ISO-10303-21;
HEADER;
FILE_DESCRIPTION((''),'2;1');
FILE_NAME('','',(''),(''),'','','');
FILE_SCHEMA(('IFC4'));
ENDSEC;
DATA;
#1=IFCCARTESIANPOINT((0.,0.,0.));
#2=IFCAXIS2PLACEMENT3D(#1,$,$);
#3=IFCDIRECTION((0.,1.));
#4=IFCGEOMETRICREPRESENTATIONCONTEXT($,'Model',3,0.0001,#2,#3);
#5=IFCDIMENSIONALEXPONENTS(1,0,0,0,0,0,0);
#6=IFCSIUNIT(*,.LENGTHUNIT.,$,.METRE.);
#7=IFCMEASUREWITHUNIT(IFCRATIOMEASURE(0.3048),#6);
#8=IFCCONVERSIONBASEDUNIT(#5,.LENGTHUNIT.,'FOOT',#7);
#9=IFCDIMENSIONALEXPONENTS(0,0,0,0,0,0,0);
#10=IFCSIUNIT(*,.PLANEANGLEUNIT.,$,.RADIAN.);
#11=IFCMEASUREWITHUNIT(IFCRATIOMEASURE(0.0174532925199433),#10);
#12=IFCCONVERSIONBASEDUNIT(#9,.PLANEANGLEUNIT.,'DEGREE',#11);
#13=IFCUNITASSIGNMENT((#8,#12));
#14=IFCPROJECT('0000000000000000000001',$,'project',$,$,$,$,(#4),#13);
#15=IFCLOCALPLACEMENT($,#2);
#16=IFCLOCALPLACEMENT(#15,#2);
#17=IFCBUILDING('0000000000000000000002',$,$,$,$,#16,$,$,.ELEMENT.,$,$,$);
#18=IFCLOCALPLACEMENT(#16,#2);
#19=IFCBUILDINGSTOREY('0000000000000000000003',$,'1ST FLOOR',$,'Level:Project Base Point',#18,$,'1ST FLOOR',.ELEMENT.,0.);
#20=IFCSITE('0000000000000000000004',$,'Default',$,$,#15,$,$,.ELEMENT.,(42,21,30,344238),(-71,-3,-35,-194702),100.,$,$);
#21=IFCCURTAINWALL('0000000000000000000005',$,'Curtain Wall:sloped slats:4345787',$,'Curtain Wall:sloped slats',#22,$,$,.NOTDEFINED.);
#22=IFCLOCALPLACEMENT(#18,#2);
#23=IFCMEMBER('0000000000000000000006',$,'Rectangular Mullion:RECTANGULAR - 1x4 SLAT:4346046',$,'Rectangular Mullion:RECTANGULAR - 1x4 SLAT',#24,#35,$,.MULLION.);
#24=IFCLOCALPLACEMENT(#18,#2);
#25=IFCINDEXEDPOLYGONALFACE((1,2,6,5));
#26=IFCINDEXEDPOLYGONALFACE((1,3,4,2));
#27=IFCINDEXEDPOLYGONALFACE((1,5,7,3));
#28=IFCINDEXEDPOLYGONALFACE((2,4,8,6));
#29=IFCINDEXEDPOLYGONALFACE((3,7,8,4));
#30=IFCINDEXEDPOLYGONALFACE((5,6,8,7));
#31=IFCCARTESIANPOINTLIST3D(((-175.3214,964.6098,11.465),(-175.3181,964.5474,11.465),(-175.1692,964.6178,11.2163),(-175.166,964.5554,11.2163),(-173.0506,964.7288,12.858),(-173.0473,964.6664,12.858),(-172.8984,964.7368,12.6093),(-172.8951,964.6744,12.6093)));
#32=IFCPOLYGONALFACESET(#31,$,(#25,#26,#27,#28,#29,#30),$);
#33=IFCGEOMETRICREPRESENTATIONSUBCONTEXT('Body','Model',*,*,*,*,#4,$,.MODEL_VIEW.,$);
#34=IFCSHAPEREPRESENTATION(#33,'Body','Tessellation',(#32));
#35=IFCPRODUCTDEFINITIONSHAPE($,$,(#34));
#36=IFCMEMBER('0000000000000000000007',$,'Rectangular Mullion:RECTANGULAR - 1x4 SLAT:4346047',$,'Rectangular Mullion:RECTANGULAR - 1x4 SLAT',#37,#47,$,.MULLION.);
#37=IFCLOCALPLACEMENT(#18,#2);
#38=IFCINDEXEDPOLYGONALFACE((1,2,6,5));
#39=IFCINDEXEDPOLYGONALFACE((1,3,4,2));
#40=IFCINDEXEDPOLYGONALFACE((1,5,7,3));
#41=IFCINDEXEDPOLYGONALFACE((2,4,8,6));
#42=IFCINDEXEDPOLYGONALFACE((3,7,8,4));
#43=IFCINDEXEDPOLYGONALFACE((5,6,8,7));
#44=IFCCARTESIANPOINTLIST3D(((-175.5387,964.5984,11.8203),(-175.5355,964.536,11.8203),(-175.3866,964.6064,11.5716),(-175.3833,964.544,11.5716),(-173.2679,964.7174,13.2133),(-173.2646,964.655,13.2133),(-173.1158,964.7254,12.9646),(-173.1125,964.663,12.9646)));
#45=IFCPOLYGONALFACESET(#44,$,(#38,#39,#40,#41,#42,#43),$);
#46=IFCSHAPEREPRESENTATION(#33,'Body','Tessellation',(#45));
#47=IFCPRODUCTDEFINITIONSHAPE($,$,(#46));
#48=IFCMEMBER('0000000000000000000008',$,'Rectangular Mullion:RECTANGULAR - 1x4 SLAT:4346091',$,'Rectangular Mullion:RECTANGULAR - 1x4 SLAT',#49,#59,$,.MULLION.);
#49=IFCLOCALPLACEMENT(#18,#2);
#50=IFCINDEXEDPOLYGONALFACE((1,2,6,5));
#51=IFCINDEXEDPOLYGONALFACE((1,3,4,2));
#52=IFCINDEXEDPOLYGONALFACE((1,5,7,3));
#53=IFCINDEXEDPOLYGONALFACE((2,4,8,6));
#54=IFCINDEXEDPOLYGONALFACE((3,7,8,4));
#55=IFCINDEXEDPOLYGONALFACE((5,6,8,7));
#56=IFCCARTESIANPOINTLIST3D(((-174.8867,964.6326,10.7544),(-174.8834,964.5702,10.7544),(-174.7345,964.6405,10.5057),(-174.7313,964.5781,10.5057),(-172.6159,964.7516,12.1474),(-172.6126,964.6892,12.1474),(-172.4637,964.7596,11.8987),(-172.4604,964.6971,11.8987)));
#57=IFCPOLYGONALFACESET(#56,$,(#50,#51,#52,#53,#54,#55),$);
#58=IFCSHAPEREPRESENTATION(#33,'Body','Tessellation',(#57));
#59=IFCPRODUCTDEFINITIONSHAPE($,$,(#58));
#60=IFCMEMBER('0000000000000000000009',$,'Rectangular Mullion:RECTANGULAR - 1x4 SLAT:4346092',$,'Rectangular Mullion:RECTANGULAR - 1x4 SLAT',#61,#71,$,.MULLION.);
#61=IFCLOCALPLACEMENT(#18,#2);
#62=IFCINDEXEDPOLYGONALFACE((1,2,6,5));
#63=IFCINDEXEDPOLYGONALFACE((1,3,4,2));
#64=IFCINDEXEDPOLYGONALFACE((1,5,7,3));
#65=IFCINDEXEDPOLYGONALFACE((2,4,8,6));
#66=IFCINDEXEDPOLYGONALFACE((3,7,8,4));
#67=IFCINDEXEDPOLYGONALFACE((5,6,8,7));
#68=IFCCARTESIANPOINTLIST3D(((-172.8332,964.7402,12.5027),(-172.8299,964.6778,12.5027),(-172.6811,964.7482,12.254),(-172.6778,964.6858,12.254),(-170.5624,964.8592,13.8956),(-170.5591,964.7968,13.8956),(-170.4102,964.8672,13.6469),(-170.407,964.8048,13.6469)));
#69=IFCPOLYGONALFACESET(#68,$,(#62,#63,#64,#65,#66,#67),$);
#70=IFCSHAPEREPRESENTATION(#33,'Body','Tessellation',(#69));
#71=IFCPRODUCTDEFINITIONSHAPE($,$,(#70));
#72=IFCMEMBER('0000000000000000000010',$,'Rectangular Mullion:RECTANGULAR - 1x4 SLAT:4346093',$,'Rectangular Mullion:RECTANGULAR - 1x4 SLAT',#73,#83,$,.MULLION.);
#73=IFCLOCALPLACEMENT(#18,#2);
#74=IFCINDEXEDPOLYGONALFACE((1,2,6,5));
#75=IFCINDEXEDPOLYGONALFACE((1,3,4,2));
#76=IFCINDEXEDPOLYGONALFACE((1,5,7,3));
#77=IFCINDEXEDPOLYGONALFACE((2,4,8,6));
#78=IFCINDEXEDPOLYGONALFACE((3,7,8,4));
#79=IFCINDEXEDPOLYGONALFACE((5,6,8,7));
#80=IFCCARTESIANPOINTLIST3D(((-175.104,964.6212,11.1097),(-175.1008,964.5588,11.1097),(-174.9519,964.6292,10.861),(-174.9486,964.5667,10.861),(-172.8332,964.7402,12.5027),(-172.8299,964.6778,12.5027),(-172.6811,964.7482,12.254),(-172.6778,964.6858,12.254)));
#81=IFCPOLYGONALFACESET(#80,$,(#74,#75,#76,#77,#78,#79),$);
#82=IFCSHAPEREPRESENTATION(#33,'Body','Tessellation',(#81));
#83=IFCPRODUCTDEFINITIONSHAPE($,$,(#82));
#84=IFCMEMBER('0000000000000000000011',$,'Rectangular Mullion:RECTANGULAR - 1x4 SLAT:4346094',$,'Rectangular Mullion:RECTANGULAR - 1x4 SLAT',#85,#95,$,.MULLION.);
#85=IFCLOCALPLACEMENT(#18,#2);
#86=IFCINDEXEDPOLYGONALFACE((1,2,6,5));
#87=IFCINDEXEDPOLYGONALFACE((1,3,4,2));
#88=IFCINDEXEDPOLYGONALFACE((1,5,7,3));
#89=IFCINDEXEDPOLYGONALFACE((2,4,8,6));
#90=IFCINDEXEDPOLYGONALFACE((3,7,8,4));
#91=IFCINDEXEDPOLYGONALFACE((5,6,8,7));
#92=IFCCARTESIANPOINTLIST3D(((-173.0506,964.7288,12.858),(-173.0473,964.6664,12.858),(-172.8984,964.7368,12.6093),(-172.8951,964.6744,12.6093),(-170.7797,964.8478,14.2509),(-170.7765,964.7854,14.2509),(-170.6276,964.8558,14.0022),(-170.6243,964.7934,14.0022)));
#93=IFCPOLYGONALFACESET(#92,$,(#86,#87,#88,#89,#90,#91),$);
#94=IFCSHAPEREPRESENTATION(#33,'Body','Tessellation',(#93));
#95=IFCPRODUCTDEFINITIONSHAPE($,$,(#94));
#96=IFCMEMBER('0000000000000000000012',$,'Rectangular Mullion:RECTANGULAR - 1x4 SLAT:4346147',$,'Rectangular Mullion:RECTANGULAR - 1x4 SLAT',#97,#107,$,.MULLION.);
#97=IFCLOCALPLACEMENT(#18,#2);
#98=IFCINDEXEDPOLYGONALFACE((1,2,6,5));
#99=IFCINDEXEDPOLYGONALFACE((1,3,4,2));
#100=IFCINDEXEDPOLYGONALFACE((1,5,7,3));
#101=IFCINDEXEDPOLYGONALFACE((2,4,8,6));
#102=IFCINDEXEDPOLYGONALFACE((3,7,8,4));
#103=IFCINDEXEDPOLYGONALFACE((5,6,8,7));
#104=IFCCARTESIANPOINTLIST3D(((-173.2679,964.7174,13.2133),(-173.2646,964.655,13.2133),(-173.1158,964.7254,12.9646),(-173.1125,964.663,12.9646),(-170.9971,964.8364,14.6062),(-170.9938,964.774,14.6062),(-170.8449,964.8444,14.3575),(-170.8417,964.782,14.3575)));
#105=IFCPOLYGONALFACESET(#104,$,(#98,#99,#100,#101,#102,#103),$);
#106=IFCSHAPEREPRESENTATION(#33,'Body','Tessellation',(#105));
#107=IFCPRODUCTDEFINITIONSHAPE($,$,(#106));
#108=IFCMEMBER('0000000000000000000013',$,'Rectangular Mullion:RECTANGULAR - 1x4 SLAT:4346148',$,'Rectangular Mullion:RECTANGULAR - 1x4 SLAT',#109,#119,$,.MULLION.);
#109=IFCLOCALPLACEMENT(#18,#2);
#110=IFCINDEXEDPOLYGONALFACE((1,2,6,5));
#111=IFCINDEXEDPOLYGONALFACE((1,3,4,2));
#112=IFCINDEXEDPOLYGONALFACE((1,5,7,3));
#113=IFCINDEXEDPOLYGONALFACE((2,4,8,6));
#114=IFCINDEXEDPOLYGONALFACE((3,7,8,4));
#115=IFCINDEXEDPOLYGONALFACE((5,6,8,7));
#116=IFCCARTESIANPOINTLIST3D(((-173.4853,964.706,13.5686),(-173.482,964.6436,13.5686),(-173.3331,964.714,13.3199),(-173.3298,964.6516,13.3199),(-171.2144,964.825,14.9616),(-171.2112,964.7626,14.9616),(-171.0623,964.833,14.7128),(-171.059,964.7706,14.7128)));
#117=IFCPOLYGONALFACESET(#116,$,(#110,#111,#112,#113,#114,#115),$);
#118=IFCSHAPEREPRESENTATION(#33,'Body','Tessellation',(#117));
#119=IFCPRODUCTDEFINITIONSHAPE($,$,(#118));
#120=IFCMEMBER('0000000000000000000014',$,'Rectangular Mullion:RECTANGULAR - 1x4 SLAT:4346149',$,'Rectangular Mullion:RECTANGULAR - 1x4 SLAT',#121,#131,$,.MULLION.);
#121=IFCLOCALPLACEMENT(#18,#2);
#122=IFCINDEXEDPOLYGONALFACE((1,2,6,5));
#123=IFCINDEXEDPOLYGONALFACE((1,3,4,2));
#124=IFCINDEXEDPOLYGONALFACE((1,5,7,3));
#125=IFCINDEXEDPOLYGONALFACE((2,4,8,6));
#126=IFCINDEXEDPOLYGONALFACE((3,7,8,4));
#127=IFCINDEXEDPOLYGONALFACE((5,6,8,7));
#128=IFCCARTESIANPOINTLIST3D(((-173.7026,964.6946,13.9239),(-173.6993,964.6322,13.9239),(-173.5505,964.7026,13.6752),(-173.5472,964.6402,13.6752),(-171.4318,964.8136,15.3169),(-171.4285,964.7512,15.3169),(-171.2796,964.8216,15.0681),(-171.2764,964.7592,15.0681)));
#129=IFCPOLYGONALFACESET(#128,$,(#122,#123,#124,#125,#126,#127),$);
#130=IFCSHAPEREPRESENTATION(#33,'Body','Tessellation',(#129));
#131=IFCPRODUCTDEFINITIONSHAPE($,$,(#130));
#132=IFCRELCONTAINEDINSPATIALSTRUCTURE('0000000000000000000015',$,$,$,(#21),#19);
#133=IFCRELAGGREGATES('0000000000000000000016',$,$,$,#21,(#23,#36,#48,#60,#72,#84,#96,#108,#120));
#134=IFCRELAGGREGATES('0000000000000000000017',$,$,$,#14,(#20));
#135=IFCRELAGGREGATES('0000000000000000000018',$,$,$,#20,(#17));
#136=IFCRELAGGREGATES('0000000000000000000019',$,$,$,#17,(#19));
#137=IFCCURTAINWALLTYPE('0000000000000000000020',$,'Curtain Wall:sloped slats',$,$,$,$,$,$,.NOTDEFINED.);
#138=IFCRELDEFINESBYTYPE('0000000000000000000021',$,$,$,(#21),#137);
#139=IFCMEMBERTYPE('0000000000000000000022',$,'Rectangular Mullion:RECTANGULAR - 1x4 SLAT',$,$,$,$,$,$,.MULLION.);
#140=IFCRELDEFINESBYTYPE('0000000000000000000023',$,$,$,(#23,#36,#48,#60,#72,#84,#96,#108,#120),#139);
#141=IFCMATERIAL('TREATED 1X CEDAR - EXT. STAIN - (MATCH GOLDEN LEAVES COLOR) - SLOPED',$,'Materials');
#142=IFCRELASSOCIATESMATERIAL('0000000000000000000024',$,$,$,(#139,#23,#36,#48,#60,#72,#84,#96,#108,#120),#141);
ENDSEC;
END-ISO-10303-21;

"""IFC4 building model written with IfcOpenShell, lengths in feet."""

from ifc_helpers import new_model, entity, si_unit, converted_unit, direction, frame, frame_2d, origin, place, context, subcontext, project, spatial, rectangle, extrude, source, transform, mapped, material, material_profile, profile_set, profile_usage, type_object, type_shapes, element, aggregate, save


model = new_model("IFC4")

# Units and contexts
model_context = context("Model", 3, precision=0.0001, world=origin(), true_north=direction((0.0, 1.0)))
body_context = subcontext(model_context, "Body", "Model", "MODEL_VIEW")
ifc_project = project(units=[converted_unit("LENGTHUNIT", "FOOT", entity("IfcRatioMeasure", 0.3048), si_unit("LENGTHUNIT", "METRE"), dimensions=[1, 0, 0, 0, 0, 0, 0]), converted_unit("PLANEANGLEUNIT", "DEGREE", entity("IfcRatioMeasure", 0.0174532925199433), si_unit("PLANEANGLEUNIT", "RADIAN"), dimensions=[0, 0, 0, 0, 0, 0, 0])], contexts=[model_context])

# Site, building, storey
site_placement = place(None, origin())
site = spatial("IfcSite", under=ifc_project, at=site_placement, Name="Default", CompositionType="ELEMENT", RefLatitude=(42, 21, 30, 344238), RefLongitude=(-71, -3, -35, -194702), RefElevation=100.0)
building_placement = place(site_placement, origin())
building = spatial("IfcBuilding", under=site, at=building_placement, CompositionType="ELEMENT")
storey_placement = place(building_placement, origin())
storey = spatial("IfcBuildingStorey", under=building, at=storey_placement, Name="1ST FLOOR", ObjectType="Level:Project Base Point", LongName="1ST FLOOR", CompositionType="ELEMENT", Elevation=0.0)

# Curtain wall, members
curtain_wall_type_1 = type_object("IfcCurtainWallType", Name="Curtain Wall:sloped slats", PredefinedType="NOTDEFINED")
curtain_wall_1_placement = place(storey_placement, origin())
curtain_wall_1 = element("IfcCurtainWall", 1, at=curtain_wall_1_placement, inside=storey, type_object=curtain_wall_type_1, Name="Curtain Wall:sloped slats:4345787", ObjectType="Curtain Wall:sloped slats", PredefinedType="NOTDEFINED")
ifc_material_1 = material(Name="TREATED 1X CEDAR - EXT. STAIN - (MATCH GOLDEN LEAVES COLOR) - SLOPED", Category="Materials")
ifc_material_profile_1 = material_profile(ifc_material_1, rectangle(XDim=0.0625, YDim=0.2917, at=frame_2d((0.0, 0.0), x_axis=(1.0, 0.0))), Name="RECTANGULAR - 1x4 SLAT")
ifc_profile_set_1 = profile_set([ifc_material_profile_1], Name="RECTANGULAR - 1x4 SLAT")
member_type_1 = type_object("IfcMemberType", Name="Rectangular Mullion:RECTANGULAR - 1x4 SLAT", PredefinedType="MULLION", material=ifc_profile_set_1)
shared_shape_1 = source(origin(), body_context, "Body", "SweptSolid", [
    extrude(rectangle(XDim=0.0625, YDim=0.2917, at=frame_2d((0.0, 0.0), x_axis=(1.0, 0.0))), frame((0.0, 0.0, -2.6667), z_axis=(0.0, 0.0, 1.0), x_axis=(0.0, -1.0, 0.0)), (0.0, 0.0, 1.0), 2.6667),
])
type_shapes(member_type_1, [shared_shape_1])
ifc_profile_usage_1 = profile_usage(ifc_profile_set_1)
member_1_placement = place(storey_placement, frame((-175.2437, 964.5826, 11.3407), z_axis=(-0.851559, -0.044628, -0.522356), x_axis=(-0.52164, -0.027338, 0.852727)))
member_1 = element("IfcMember", 2, at=member_1_placement, type_object=member_type_1, material=ifc_profile_usage_1, Name="Rectangular Mullion:RECTANGULAR - 1x4 SLAT:4346046", ObjectType="Rectangular Mullion:RECTANGULAR - 1x4 SLAT", PredefinedType="MULLION", context=body_context, shape_type="MappedRepresentation", body=[
    mapped(shared_shape_1, transform((0.0, 0.0, 0.0), scale=1.0)),
])
ifc_profile_usage_2 = profile_usage(ifc_profile_set_1)
member_2_placement = place(storey_placement, frame((-175.461, 964.5712, 11.696), z_axis=(-0.851559, -0.044628, -0.522356), x_axis=(-0.52164, -0.027338, 0.852727)))
member_2 = element("IfcMember", 3, at=member_2_placement, type_object=member_type_1, material=ifc_profile_usage_2, Name="Rectangular Mullion:RECTANGULAR - 1x4 SLAT:4346047", ObjectType="Rectangular Mullion:RECTANGULAR - 1x4 SLAT", PredefinedType="MULLION", context=body_context, shape_type="MappedRepresentation", body=[
    mapped(shared_shape_1, transform((0.0, 0.0, 0.0), scale=1.0)),
])
ifc_profile_usage_3 = profile_usage(ifc_profile_set_1)
member_3_placement = place(storey_placement, frame((-174.809, 964.6054, 10.6301), z_axis=(-0.851559, -0.044628, -0.522356), x_axis=(-0.52164, -0.027338, 0.852727)))
member_3 = element("IfcMember", 4, at=member_3_placement, type_object=member_type_1, material=ifc_profile_usage_3, Name="Rectangular Mullion:RECTANGULAR - 1x4 SLAT:4346091", ObjectType="Rectangular Mullion:RECTANGULAR - 1x4 SLAT", PredefinedType="MULLION", context=body_context, shape_type="MappedRepresentation", body=[
    mapped(shared_shape_1, transform((0.0, 0.0, 0.0), scale=1.0)),
])
ifc_profile_usage_4 = profile_usage(ifc_profile_set_1)
member_4_placement = place(storey_placement, frame((-172.7555, 964.713, 12.3783), z_axis=(-0.851559, -0.044628, -0.522356), x_axis=(-0.52164, -0.027338, 0.852727)))
member_4 = element("IfcMember", 5, at=member_4_placement, type_object=member_type_1, material=ifc_profile_usage_4, Name="Rectangular Mullion:RECTANGULAR - 1x4 SLAT:4346092", ObjectType="Rectangular Mullion:RECTANGULAR - 1x4 SLAT", PredefinedType="MULLION", context=body_context, shape_type="MappedRepresentation", body=[
    mapped(shared_shape_1, transform((0.0, 0.0, 0.0), scale=1.0)),
])
ifc_profile_usage_5 = profile_usage(ifc_profile_set_1)
member_5_placement = place(storey_placement, frame((-175.0263, 964.594, 10.9854), z_axis=(-0.851559, -0.044628, -0.522356), x_axis=(-0.52164, -0.027338, 0.852727)))
member_5 = element("IfcMember", 6, at=member_5_placement, type_object=member_type_1, material=ifc_profile_usage_5, Name="Rectangular Mullion:RECTANGULAR - 1x4 SLAT:4346093", ObjectType="Rectangular Mullion:RECTANGULAR - 1x4 SLAT", PredefinedType="MULLION", context=body_context, shape_type="MappedRepresentation", body=[
    mapped(shared_shape_1, transform((0.0, 0.0, 0.0), scale=1.0)),
])
ifc_profile_usage_6 = profile_usage(ifc_profile_set_1)
member_6_placement = place(storey_placement, frame((-172.9729, 964.7016, 12.7336), z_axis=(-0.851559, -0.044628, -0.522356), x_axis=(-0.52164, -0.027338, 0.852727)))
member_6 = element("IfcMember", 7, at=member_6_placement, type_object=member_type_1, material=ifc_profile_usage_6, Name="Rectangular Mullion:RECTANGULAR - 1x4 SLAT:4346094", ObjectType="Rectangular Mullion:RECTANGULAR - 1x4 SLAT", PredefinedType="MULLION", context=body_context, shape_type="MappedRepresentation", body=[
    mapped(shared_shape_1, transform((0.0, 0.0, 0.0), scale=1.0)),
])
ifc_profile_usage_7 = profile_usage(ifc_profile_set_1)
member_7_placement = place(storey_placement, frame((-173.1902, 964.6902, 13.0889), z_axis=(-0.851559, -0.044628, -0.522356), x_axis=(-0.52164, -0.027338, 0.852727)))
member_7 = element("IfcMember", 8, at=member_7_placement, type_object=member_type_1, material=ifc_profile_usage_7, Name="Rectangular Mullion:RECTANGULAR - 1x4 SLAT:4346147", ObjectType="Rectangular Mullion:RECTANGULAR - 1x4 SLAT", PredefinedType="MULLION", context=body_context, shape_type="MappedRepresentation", body=[
    mapped(shared_shape_1, transform((0.0, 0.0, 0.0), scale=1.0)),
])
ifc_profile_usage_8 = profile_usage(ifc_profile_set_1)
member_8_placement = place(storey_placement, frame((-173.4076, 964.6788, 13.4442), z_axis=(-0.851559, -0.044628, -0.522356), x_axis=(-0.52164, -0.027338, 0.852727)))
member_8 = element("IfcMember", 9, at=member_8_placement, type_object=member_type_1, material=ifc_profile_usage_8, Name="Rectangular Mullion:RECTANGULAR - 1x4 SLAT:4346148", ObjectType="Rectangular Mullion:RECTANGULAR - 1x4 SLAT", PredefinedType="MULLION", context=body_context, shape_type="MappedRepresentation", body=[
    mapped(shared_shape_1, transform((0.0, 0.0, 0.0), scale=1.0)),
])
ifc_profile_usage_9 = profile_usage(ifc_profile_set_1)
member_9_placement = place(storey_placement, frame((-173.6249, 964.6674, 13.7995), z_axis=(-0.851559, -0.044628, -0.522356), x_axis=(-0.52164, -0.027338, 0.852727)))
member_9 = element("IfcMember", 10, at=member_9_placement, type_object=member_type_1, material=ifc_profile_usage_9, Name="Rectangular Mullion:RECTANGULAR - 1x4 SLAT:4346149", ObjectType="Rectangular Mullion:RECTANGULAR - 1x4 SLAT", PredefinedType="MULLION", context=body_context, shape_type="MappedRepresentation", body=[
    mapped(shared_shape_1, transform((0.0, 0.0, 0.0), scale=1.0)),
])
aggregate(curtain_wall_1, [member_1, member_2, member_3, member_4, member_5, member_6, member_7, member_8, member_9])

save(model, "model.ifc")
